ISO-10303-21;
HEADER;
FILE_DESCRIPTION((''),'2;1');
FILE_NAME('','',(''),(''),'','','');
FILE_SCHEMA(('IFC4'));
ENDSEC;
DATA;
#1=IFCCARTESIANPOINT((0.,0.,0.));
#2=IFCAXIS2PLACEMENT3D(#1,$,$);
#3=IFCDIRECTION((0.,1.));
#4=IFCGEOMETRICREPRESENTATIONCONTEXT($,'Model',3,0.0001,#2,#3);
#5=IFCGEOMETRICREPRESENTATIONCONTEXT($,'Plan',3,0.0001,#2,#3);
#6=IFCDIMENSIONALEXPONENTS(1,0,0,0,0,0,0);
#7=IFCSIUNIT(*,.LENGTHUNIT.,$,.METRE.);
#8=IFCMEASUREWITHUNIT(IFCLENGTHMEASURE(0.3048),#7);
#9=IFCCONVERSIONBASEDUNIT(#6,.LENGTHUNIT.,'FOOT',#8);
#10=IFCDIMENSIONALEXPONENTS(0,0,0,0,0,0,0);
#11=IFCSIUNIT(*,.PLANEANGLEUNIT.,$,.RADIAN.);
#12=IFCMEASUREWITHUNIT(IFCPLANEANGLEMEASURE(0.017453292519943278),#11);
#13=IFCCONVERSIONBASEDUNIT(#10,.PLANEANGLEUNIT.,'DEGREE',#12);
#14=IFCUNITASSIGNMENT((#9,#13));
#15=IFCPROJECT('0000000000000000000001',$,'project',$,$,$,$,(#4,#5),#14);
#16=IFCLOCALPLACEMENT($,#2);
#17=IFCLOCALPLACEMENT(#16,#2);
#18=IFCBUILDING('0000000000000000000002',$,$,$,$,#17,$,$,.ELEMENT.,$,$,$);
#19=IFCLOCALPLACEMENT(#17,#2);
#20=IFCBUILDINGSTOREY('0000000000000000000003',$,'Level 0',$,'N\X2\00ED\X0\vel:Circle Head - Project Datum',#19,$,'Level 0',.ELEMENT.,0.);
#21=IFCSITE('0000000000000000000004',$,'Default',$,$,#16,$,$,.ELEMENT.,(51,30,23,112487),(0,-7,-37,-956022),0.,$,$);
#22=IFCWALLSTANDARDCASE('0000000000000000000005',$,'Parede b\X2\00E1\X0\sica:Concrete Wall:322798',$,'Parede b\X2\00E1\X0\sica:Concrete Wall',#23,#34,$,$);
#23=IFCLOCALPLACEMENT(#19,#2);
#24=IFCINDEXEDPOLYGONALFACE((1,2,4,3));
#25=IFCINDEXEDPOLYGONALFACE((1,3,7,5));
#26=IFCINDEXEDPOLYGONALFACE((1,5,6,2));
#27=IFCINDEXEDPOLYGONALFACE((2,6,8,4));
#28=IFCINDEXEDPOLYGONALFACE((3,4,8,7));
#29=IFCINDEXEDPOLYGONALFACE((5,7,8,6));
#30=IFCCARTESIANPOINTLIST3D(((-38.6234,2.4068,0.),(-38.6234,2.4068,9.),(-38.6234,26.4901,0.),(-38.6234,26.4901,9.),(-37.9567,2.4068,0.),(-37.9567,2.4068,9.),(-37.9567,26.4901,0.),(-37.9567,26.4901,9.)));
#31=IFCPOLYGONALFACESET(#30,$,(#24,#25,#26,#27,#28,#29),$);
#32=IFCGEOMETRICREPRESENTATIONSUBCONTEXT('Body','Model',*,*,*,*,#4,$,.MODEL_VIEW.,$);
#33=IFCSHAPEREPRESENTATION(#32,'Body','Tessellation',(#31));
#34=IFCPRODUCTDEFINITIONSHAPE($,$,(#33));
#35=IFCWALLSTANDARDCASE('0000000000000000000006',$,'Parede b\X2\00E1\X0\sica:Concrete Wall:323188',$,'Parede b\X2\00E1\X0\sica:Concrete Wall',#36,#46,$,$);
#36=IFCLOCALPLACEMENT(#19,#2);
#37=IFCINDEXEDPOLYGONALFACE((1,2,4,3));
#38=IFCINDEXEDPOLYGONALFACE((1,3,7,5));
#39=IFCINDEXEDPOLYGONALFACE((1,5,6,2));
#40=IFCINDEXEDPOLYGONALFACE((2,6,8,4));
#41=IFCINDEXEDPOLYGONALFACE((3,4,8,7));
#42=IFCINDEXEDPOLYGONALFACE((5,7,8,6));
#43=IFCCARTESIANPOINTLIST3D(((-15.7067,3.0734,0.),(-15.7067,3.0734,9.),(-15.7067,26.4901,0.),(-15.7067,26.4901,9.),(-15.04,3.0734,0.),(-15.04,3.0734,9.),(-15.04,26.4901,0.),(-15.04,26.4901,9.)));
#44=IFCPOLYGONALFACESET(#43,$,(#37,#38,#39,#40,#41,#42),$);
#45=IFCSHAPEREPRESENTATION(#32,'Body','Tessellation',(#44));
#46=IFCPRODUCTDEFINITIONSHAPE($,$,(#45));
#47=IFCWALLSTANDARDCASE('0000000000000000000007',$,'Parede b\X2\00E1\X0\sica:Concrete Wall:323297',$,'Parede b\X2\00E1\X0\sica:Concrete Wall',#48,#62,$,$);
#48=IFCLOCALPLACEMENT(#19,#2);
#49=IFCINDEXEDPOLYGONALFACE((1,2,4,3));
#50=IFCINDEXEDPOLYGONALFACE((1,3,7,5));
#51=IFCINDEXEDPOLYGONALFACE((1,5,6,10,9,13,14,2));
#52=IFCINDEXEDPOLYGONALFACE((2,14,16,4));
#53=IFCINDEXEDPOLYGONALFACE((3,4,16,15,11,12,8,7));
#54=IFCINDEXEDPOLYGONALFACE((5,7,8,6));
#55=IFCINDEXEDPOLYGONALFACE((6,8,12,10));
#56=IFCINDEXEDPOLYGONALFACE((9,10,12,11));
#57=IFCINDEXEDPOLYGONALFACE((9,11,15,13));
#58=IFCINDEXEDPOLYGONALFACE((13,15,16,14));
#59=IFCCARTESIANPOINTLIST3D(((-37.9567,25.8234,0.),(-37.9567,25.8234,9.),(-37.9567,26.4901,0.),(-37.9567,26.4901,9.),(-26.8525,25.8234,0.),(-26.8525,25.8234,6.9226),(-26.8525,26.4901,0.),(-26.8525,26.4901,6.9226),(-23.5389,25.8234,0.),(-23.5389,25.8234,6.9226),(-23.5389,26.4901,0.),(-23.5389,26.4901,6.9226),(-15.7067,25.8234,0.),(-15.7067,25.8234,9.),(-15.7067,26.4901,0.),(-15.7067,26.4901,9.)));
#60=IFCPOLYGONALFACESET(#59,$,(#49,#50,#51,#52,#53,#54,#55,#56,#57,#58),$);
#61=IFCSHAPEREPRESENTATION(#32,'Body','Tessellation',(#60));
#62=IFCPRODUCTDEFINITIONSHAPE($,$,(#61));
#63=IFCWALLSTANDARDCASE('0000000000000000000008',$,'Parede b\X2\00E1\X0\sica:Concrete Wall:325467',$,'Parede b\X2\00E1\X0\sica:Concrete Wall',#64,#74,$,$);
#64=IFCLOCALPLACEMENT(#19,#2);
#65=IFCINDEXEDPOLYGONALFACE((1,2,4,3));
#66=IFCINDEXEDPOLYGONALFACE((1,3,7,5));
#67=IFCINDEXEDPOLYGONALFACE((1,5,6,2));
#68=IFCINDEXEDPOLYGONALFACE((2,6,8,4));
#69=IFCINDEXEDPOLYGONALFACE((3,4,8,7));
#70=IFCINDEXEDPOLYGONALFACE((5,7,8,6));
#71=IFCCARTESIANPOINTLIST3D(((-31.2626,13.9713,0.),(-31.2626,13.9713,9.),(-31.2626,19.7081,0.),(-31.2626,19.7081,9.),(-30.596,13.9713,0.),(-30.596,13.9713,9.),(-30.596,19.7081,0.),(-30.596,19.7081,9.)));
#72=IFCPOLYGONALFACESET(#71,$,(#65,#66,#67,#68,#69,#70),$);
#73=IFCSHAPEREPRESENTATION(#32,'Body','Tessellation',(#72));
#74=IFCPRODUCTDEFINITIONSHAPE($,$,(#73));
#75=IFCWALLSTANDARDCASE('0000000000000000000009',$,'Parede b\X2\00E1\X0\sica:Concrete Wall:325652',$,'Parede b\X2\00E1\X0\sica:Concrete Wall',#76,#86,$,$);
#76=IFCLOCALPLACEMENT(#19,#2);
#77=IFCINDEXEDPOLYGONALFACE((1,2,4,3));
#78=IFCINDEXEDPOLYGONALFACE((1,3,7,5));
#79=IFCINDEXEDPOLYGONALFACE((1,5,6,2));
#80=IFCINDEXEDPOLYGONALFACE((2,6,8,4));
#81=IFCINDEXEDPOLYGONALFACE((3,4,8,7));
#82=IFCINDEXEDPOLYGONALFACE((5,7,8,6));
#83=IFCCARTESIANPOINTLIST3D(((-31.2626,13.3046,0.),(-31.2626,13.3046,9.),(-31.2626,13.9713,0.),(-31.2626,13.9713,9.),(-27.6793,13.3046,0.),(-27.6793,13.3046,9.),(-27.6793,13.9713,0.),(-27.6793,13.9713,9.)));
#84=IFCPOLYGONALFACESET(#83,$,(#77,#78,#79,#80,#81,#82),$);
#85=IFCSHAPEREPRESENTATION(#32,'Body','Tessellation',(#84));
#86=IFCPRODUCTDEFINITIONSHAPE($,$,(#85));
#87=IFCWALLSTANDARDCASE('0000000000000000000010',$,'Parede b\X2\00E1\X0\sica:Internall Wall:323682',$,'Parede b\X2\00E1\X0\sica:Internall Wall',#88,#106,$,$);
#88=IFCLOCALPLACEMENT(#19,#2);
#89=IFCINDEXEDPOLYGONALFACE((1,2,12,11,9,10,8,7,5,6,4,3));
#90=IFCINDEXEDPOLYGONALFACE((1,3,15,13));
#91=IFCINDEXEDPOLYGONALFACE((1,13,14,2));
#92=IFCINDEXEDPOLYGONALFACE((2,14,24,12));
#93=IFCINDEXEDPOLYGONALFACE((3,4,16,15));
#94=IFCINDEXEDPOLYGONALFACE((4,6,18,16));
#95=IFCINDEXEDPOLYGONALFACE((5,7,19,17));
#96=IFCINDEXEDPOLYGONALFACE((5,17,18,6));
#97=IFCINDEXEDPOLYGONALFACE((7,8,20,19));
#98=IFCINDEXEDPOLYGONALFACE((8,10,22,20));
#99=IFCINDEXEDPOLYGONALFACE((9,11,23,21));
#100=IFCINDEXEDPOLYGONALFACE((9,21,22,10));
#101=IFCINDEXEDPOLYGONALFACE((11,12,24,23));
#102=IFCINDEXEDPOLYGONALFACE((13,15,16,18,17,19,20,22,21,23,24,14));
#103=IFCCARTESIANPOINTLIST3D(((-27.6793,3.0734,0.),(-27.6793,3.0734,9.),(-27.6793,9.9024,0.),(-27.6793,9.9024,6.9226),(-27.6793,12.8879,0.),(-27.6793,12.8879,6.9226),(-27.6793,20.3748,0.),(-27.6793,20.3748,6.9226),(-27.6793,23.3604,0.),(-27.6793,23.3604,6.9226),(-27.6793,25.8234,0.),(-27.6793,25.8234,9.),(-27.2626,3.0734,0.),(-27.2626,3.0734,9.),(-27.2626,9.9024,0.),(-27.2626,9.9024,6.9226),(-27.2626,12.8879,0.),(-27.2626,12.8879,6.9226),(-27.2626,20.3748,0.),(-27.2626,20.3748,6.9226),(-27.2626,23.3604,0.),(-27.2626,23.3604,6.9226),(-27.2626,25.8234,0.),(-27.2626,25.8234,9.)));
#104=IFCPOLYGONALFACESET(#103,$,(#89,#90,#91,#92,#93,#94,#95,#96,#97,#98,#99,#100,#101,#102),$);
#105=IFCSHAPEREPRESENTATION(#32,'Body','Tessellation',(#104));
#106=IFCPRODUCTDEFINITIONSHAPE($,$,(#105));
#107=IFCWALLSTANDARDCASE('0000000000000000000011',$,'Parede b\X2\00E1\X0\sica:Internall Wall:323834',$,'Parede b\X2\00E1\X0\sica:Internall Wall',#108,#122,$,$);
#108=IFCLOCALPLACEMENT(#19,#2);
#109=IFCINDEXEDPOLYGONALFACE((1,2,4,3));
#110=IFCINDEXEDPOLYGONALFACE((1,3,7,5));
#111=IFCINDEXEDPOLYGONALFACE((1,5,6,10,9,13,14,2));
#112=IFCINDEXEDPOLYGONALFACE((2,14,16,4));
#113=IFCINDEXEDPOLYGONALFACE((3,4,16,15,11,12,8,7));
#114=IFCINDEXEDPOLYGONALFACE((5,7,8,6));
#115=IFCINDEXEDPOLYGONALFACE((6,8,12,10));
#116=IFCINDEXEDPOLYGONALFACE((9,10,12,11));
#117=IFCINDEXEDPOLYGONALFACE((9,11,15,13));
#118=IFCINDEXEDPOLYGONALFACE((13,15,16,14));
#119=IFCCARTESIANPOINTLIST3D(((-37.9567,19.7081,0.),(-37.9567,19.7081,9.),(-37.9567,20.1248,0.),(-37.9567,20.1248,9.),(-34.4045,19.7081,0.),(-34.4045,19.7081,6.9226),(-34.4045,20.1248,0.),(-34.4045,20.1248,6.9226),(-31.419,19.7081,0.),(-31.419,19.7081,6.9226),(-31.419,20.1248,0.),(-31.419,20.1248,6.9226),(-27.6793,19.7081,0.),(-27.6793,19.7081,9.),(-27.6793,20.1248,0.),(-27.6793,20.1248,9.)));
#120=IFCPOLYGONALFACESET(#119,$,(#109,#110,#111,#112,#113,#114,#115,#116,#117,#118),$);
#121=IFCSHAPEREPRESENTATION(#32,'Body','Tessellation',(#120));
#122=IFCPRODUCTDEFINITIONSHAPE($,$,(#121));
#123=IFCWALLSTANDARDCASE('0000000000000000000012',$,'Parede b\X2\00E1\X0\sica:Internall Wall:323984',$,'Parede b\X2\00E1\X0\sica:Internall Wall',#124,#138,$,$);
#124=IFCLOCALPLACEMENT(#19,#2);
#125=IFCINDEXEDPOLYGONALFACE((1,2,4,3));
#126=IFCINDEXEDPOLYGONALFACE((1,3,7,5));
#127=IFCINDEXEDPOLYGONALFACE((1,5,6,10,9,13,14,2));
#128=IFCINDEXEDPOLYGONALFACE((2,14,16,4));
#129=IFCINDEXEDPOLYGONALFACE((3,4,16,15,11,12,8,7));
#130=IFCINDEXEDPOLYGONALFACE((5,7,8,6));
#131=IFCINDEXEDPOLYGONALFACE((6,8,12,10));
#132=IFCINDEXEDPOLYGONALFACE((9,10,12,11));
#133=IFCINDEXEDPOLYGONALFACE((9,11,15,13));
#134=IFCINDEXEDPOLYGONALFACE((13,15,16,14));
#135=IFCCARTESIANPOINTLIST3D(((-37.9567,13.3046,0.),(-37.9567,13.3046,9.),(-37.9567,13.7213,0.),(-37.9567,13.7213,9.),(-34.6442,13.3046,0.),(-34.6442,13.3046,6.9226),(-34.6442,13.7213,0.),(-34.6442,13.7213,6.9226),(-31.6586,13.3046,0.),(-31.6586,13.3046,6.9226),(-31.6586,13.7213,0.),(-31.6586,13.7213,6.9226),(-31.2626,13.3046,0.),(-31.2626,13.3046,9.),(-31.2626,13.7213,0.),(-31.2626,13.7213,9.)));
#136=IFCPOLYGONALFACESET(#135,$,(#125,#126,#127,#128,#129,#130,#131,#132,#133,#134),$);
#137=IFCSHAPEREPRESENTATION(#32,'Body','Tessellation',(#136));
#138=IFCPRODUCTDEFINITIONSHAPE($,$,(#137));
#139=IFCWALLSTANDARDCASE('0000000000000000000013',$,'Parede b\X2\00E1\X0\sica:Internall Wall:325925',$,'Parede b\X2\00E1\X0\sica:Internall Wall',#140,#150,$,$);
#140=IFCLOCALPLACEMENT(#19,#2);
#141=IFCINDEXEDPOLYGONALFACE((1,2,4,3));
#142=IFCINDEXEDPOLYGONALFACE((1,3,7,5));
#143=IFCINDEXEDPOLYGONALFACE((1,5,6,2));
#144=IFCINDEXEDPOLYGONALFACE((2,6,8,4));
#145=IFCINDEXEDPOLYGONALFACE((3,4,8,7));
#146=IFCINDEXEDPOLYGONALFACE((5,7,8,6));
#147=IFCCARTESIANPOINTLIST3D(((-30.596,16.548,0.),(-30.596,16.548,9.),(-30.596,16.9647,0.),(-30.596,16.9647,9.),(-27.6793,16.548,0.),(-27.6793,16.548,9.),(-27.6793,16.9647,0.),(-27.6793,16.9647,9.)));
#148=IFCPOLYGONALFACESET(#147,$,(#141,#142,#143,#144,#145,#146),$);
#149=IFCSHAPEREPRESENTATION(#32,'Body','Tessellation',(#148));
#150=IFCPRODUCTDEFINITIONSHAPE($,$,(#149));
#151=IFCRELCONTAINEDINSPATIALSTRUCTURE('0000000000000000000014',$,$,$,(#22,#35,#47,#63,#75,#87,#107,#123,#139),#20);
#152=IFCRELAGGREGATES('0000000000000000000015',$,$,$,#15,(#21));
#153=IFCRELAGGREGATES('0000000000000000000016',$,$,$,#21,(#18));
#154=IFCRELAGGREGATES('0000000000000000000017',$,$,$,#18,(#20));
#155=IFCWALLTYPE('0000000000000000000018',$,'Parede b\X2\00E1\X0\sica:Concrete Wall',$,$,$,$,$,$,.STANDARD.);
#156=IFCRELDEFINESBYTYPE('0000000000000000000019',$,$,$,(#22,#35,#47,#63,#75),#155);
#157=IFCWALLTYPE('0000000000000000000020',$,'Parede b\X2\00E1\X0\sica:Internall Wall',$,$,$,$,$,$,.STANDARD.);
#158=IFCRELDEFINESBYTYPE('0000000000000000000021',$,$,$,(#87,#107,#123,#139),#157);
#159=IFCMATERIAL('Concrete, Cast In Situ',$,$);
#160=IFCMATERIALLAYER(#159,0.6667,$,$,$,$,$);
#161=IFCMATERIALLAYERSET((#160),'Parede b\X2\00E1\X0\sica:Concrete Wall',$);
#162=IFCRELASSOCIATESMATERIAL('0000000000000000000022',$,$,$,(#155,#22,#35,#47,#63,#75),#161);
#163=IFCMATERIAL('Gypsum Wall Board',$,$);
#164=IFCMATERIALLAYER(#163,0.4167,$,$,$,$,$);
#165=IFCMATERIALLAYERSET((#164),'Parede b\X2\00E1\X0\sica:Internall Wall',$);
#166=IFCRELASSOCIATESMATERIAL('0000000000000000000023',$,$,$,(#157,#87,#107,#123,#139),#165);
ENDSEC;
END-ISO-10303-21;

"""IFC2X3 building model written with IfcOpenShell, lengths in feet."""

from ifc_helpers import new_model, entity, si_unit, converted_unit, direction, frame, frame_2d, origin, place, context, subcontext, project, spatial, rectangle, extrude, material, layer, layer_set, layer_usage, type_object, element, save


model = new_model("IFC2X3")

# Units and contexts
model_context = context("Model", 3, precision=0.0001, world=origin(), true_north=direction((0.0, 1.0)))
plan_context = context("Plan", 3, precision=0.0001, world=origin(), true_north=direction((0.0, 1.0)))
body_context = subcontext(model_context, "Body", "Model", "MODEL_VIEW")
ifc_project = project(units=[converted_unit("LENGTHUNIT", "FOOT", entity("IfcLengthMeasure", 0.3048), si_unit("LENGTHUNIT", "METRE"), dimensions=[1, 0, 0, 0, 0, 0, 0]), converted_unit("PLANEANGLEUNIT", "DEGREE", entity("IfcPlaneAngleMeasure", 0.017453292519943278), si_unit("PLANEANGLEUNIT", "RADIAN"), dimensions=[0, 0, 0, 0, 0, 0, 0])], contexts=[model_context, plan_context])

# Site, building, storey
site_placement = place(None, origin())
site = spatial("IfcSite", under=ifc_project, at=site_placement, Name="Default", CompositionType="ELEMENT", RefLatitude=(51, 30, 23, 112487), RefLongitude=(0, -7, -37, -956022), RefElevation=0.0)
building_placement = place(site_placement, origin())
building = spatial("IfcBuilding", under=site, at=building_placement, CompositionType="ELEMENT")
storey_placement = place(building_placement, origin())
storey = spatial("IfcBuildingStorey", under=building, at=storey_placement, Name="Level 0", ObjectType="Nível:Circle Head - Project Datum", LongName="Level 0", CompositionType="ELEMENT", Elevation=0.0)

# Wall
ifc_material_1 = material(Name="Concrete, Cast In Situ")
ifc_layer_1 = layer(ifc_material_1, 0.6667)
ifc_layer_set_1 = layer_set([ifc_layer_1], Name="Parede básica:Concrete Wall")
ifc_layer_usage_1 = layer_usage(ifc_layer_set_1, "AXIS2", "POSITIVE", -0.3333)
wall_type_1 = type_object("IfcWallType", Name="Parede básica:Concrete Wall", PredefinedType="STANDARD", material=ifc_layer_set_1)
wall_1_placement = place(storey_placement, frame((-38.29, 26.4901, 0.0), z_axis=(0.0, 0.0, 1.0), x_axis=(0.0, -1.0, 0.0)))
element("IfcWallStandardCase", 1, at=wall_1_placement, inside=storey, type_object=wall_type_1, material=ifc_layer_usage_1, Name="Parede básica:Concrete Wall:322798", ObjectType="Parede básica:Concrete Wall", context=body_context, shape_type="SweptSolid", body=[
    extrude(rectangle(XDim=24.0833, YDim=0.6667, at=frame_2d((12.0417, 0.0), x_axis=(-1.0, 0.0))), origin(), (0.0, 0.0, 1.0), 9.0),
])

# Wall
ifc_layer_usage_2 = layer_usage(ifc_layer_set_1, "AXIS2", "POSITIVE", -0.3333)
wall_2_placement = place(storey_placement, frame((-15.3734, 3.0734, 0.0), z_axis=(0.0, 0.0, 1.0), x_axis=(0.0, 1.0, 0.0)))
element("IfcWallStandardCase", 2, at=wall_2_placement, inside=storey, type_object=wall_type_1, material=ifc_layer_usage_2, Name="Parede básica:Concrete Wall:323188", ObjectType="Parede básica:Concrete Wall", context=body_context, shape_type="SweptSolid", body=[
    extrude(rectangle(XDim=23.4167, YDim=0.6667, at=frame_2d((11.7083, 0.0), x_axis=(-1.0, 0.0))), origin(), (0.0, 0.0, 1.0), 9.0),
])

# Wall, opening
ifc_layer_usage_3 = layer_usage(ifc_layer_set_1, "AXIS2", "POSITIVE", -0.3333)
wall_3_placement = place(storey_placement, frame((-15.7067, 26.1568, 0.0), z_axis=(0.0, 0.0, 1.0), x_axis=(-1.0, 0.0, 0.0)))
wall_3 = element("IfcWallStandardCase", 3, at=wall_3_placement, inside=storey, type_object=wall_type_1, material=ifc_layer_usage_3, Name="Parede básica:Concrete Wall:323297", ObjectType="Parede básica:Concrete Wall", context=body_context, shape_type="SweptSolid", body=[
    extrude(rectangle(XDim=22.25, YDim=0.6667, at=frame_2d((11.125, 0.0), x_axis=(1.0, 0.0))), origin(), (0.0, 0.0, 1.0), 9.0),
])
opening_1_placement = place(wall_3_placement, frame((7.8322, -0.3333, 0.0)))
element("IfcOpeningElement", 4, at=opening_1_placement, cuts=wall_3, ObjectType="Opening", context=body_context, shape_type="SweptSolid", body=[
    extrude(rectangle(XDim=6.9226, YDim=3.3136, at=frame_2d((3.4613, 1.6568), x_axis=(1.0, 0.0))), frame((0.0, 0.0, 0.0), z_axis=(0.0, 1.0, 0.0), x_axis=(0.0, 0.0, 1.0)), (0.0, 0.0, 1.0), 0.6667),
])

# Walls
ifc_layer_usage_4 = layer_usage(ifc_layer_set_1, "AXIS2", "POSITIVE", -0.3333)
wall_4_placement = place(storey_placement, frame((-30.9293, 19.7081, 0.0), z_axis=(0.0, 0.0, 1.0), x_axis=(0.0, -1.0, 0.0)))
element("IfcWallStandardCase", 5, at=wall_4_placement, inside=storey, type_object=wall_type_1, material=ifc_layer_usage_4, Name="Parede básica:Concrete Wall:325467", ObjectType="Parede básica:Concrete Wall", context=body_context, shape_type="SweptSolid", body=[
    extrude(rectangle(XDim=5.7369, YDim=0.6667, at=frame_2d((2.8684, 0.0), x_axis=(-1.0, 0.0))), origin(), (0.0, 0.0, 1.0), 9.0),
])
ifc_layer_usage_5 = layer_usage(ifc_layer_set_1, "AXIS2", "POSITIVE", -0.3333)
wall_5_placement = place(storey_placement, frame((-31.2626, 13.6379, 0.0)))
element("IfcWallStandardCase", 6, at=wall_5_placement, inside=storey, type_object=wall_type_1, material=ifc_layer_usage_5, Name="Parede básica:Concrete Wall:325652", ObjectType="Parede básica:Concrete Wall", context=body_context, shape_type="SweptSolid", body=[
    extrude(rectangle(XDim=3.5833, YDim=0.6667, at=frame_2d((1.7917, 0.0), x_axis=(-1.0, 0.0))), origin(), (0.0, 0.0, 1.0), 9.0),
])

# Wall, openings
ifc_material_2 = material(Name="Gypsum Wall Board")
ifc_layer_2 = layer(ifc_material_2, 0.4167)
ifc_layer_set_2 = layer_set([ifc_layer_2], Name="Parede básica:Internall Wall")
ifc_layer_usage_6 = layer_usage(ifc_layer_set_2, "AXIS2", "NEGATIVE", 0.2083)
wall_type_2 = type_object("IfcWallType", Name="Parede básica:Internall Wall", PredefinedType="STANDARD", material=ifc_layer_set_2)
wall_6_placement = place(storey_placement, frame((-27.471, 3.0734, 0.0), z_axis=(0.0, 0.0, 1.0), x_axis=(0.0, 1.0, 0.0)))
wall_6 = element("IfcWallStandardCase", 7, at=wall_6_placement, inside=storey, type_object=wall_type_2, material=ifc_layer_usage_6, Name="Parede básica:Internall Wall:323682", ObjectType="Parede básica:Internall Wall", context=body_context, shape_type="SweptSolid", body=[
    extrude(rectangle(XDim=22.75, YDim=0.4167, at=frame_2d((11.375, 0.0), x_axis=(1.0, 0.0))), origin(), (0.0, 0.0, 1.0), 9.0),
])
opening_2_placement = place(wall_6_placement, frame((17.3014, -0.2083, 0.0)))
element("IfcOpeningElement", 8, at=opening_2_placement, cuts=wall_6, ObjectType="Opening", context=body_context, shape_type="SweptSolid", body=[
    extrude(rectangle(XDim=6.9226, YDim=2.9856, at=frame_2d((3.4613, 1.4928), x_axis=(1.0, 0.0))), frame((0.0, 0.0, 0.0), z_axis=(0.0, 1.0, 0.0), x_axis=(0.0, 0.0, 1.0)), (0.0, 0.0, 1.0), 0.4167),
])
opening_3_placement = place(wall_6_placement, frame((6.8289, -0.2083, 0.0)))
element("IfcOpeningElement", 9, at=opening_3_placement, cuts=wall_6, ObjectType="Opening", context=body_context, shape_type="SweptSolid", body=[
    extrude(rectangle(XDim=6.9226, YDim=2.9856, at=frame_2d((3.4613, 1.4928), x_axis=(1.0, 0.0))), frame((0.0, 0.0, 0.0), z_axis=(0.0, 1.0, 0.0), x_axis=(0.0, 0.0, 1.0)), (0.0, 0.0, 1.0), 0.4167),
])

# Walls, openings
ifc_layer_usage_7 = layer_usage(ifc_layer_set_2, "AXIS2", "NEGATIVE", 0.2083)
wall_7_placement = place(storey_placement, frame((-37.9567, 19.9165, 0.0)))
wall_7 = element("IfcWallStandardCase", 10, at=wall_7_placement, inside=storey, type_object=wall_type_2, material=ifc_layer_usage_7, Name="Parede básica:Internall Wall:323834", ObjectType="Parede básica:Internall Wall", context=body_context, shape_type="SweptSolid", body=[
    extrude(rectangle(XDim=10.2774, YDim=0.4167, at=frame_2d((5.1387, 0.0), x_axis=(1.0, 0.0))), origin(), (0.0, 0.0, 1.0), 9.0),
])
opening_4_placement = place(wall_7_placement, frame((6.5377, 0.2083, 0.0)))
element("IfcOpeningElement", 11, at=opening_4_placement, cuts=wall_7, ObjectType="Opening", context=body_context, shape_type="SweptSolid", body=[
    extrude(rectangle(XDim=6.9226, YDim=2.9856, at=frame_2d((3.4613, 1.4928), x_axis=(1.0, 0.0))), frame((0.0, 0.0, 0.0), z_axis=(0.0, -1.0, 0.0), x_axis=(0.0, 0.0, 1.0)), (0.0, 0.0, 1.0), 0.4167),
])
ifc_layer_usage_8 = layer_usage(ifc_layer_set_2, "AXIS2", "POSITIVE", -0.2083)
wall_8_placement = place(storey_placement, frame((-37.9567, 13.5129, 0.0)))
wall_8 = element("IfcWallStandardCase", 12, at=wall_8_placement, inside=storey, type_object=wall_type_2, material=ifc_layer_usage_8, Name="Parede básica:Internall Wall:323984", ObjectType="Parede básica:Internall Wall", context=body_context, shape_type="SweptSolid", body=[
    extrude(rectangle(XDim=6.6941, YDim=0.4167, at=frame_2d((3.347, 0.0), x_axis=(1.0, 0.0))), origin(), (0.0, 0.0, 1.0), 9.0),
])
opening_5_placement = place(wall_8_placement, frame((3.3125, -0.2083, 0.0)))
element("IfcOpeningElement", 13, at=opening_5_placement, cuts=wall_8, ObjectType="Opening", context=body_context, shape_type="SweptSolid", body=[
    extrude(rectangle(XDim=6.9226, YDim=2.9856, at=frame_2d((3.4613, 1.4928), x_axis=(1.0, 0.0))), frame((0.0, 0.0, 0.0), z_axis=(0.0, 1.0, 0.0), x_axis=(0.0, 0.0, 1.0)), (0.0, 0.0, 1.0), 0.4167),
])

# Wall
ifc_layer_usage_9 = layer_usage(ifc_layer_set_2, "AXIS2", "POSITIVE", -0.2083)
wall_9_placement = place(storey_placement, frame((-27.6793, 16.7564, 0.0), z_axis=(0.0, 0.0, 1.0), x_axis=(-1.0, 0.0, 0.0)))
element("IfcWallStandardCase", 14, at=wall_9_placement, inside=storey, type_object=wall_type_2, material=ifc_layer_usage_9, Name="Parede básica:Internall Wall:325925", ObjectType="Parede básica:Internall Wall", context=body_context, shape_type="SweptSolid", body=[
    extrude(rectangle(XDim=2.9167, YDim=0.4167, at=frame_2d((1.4583, 0.0), x_axis=(-1.0, 0.0))), origin(), (0.0, 0.0, 1.0), 9.0),
])

save(model, "model.ifc")
